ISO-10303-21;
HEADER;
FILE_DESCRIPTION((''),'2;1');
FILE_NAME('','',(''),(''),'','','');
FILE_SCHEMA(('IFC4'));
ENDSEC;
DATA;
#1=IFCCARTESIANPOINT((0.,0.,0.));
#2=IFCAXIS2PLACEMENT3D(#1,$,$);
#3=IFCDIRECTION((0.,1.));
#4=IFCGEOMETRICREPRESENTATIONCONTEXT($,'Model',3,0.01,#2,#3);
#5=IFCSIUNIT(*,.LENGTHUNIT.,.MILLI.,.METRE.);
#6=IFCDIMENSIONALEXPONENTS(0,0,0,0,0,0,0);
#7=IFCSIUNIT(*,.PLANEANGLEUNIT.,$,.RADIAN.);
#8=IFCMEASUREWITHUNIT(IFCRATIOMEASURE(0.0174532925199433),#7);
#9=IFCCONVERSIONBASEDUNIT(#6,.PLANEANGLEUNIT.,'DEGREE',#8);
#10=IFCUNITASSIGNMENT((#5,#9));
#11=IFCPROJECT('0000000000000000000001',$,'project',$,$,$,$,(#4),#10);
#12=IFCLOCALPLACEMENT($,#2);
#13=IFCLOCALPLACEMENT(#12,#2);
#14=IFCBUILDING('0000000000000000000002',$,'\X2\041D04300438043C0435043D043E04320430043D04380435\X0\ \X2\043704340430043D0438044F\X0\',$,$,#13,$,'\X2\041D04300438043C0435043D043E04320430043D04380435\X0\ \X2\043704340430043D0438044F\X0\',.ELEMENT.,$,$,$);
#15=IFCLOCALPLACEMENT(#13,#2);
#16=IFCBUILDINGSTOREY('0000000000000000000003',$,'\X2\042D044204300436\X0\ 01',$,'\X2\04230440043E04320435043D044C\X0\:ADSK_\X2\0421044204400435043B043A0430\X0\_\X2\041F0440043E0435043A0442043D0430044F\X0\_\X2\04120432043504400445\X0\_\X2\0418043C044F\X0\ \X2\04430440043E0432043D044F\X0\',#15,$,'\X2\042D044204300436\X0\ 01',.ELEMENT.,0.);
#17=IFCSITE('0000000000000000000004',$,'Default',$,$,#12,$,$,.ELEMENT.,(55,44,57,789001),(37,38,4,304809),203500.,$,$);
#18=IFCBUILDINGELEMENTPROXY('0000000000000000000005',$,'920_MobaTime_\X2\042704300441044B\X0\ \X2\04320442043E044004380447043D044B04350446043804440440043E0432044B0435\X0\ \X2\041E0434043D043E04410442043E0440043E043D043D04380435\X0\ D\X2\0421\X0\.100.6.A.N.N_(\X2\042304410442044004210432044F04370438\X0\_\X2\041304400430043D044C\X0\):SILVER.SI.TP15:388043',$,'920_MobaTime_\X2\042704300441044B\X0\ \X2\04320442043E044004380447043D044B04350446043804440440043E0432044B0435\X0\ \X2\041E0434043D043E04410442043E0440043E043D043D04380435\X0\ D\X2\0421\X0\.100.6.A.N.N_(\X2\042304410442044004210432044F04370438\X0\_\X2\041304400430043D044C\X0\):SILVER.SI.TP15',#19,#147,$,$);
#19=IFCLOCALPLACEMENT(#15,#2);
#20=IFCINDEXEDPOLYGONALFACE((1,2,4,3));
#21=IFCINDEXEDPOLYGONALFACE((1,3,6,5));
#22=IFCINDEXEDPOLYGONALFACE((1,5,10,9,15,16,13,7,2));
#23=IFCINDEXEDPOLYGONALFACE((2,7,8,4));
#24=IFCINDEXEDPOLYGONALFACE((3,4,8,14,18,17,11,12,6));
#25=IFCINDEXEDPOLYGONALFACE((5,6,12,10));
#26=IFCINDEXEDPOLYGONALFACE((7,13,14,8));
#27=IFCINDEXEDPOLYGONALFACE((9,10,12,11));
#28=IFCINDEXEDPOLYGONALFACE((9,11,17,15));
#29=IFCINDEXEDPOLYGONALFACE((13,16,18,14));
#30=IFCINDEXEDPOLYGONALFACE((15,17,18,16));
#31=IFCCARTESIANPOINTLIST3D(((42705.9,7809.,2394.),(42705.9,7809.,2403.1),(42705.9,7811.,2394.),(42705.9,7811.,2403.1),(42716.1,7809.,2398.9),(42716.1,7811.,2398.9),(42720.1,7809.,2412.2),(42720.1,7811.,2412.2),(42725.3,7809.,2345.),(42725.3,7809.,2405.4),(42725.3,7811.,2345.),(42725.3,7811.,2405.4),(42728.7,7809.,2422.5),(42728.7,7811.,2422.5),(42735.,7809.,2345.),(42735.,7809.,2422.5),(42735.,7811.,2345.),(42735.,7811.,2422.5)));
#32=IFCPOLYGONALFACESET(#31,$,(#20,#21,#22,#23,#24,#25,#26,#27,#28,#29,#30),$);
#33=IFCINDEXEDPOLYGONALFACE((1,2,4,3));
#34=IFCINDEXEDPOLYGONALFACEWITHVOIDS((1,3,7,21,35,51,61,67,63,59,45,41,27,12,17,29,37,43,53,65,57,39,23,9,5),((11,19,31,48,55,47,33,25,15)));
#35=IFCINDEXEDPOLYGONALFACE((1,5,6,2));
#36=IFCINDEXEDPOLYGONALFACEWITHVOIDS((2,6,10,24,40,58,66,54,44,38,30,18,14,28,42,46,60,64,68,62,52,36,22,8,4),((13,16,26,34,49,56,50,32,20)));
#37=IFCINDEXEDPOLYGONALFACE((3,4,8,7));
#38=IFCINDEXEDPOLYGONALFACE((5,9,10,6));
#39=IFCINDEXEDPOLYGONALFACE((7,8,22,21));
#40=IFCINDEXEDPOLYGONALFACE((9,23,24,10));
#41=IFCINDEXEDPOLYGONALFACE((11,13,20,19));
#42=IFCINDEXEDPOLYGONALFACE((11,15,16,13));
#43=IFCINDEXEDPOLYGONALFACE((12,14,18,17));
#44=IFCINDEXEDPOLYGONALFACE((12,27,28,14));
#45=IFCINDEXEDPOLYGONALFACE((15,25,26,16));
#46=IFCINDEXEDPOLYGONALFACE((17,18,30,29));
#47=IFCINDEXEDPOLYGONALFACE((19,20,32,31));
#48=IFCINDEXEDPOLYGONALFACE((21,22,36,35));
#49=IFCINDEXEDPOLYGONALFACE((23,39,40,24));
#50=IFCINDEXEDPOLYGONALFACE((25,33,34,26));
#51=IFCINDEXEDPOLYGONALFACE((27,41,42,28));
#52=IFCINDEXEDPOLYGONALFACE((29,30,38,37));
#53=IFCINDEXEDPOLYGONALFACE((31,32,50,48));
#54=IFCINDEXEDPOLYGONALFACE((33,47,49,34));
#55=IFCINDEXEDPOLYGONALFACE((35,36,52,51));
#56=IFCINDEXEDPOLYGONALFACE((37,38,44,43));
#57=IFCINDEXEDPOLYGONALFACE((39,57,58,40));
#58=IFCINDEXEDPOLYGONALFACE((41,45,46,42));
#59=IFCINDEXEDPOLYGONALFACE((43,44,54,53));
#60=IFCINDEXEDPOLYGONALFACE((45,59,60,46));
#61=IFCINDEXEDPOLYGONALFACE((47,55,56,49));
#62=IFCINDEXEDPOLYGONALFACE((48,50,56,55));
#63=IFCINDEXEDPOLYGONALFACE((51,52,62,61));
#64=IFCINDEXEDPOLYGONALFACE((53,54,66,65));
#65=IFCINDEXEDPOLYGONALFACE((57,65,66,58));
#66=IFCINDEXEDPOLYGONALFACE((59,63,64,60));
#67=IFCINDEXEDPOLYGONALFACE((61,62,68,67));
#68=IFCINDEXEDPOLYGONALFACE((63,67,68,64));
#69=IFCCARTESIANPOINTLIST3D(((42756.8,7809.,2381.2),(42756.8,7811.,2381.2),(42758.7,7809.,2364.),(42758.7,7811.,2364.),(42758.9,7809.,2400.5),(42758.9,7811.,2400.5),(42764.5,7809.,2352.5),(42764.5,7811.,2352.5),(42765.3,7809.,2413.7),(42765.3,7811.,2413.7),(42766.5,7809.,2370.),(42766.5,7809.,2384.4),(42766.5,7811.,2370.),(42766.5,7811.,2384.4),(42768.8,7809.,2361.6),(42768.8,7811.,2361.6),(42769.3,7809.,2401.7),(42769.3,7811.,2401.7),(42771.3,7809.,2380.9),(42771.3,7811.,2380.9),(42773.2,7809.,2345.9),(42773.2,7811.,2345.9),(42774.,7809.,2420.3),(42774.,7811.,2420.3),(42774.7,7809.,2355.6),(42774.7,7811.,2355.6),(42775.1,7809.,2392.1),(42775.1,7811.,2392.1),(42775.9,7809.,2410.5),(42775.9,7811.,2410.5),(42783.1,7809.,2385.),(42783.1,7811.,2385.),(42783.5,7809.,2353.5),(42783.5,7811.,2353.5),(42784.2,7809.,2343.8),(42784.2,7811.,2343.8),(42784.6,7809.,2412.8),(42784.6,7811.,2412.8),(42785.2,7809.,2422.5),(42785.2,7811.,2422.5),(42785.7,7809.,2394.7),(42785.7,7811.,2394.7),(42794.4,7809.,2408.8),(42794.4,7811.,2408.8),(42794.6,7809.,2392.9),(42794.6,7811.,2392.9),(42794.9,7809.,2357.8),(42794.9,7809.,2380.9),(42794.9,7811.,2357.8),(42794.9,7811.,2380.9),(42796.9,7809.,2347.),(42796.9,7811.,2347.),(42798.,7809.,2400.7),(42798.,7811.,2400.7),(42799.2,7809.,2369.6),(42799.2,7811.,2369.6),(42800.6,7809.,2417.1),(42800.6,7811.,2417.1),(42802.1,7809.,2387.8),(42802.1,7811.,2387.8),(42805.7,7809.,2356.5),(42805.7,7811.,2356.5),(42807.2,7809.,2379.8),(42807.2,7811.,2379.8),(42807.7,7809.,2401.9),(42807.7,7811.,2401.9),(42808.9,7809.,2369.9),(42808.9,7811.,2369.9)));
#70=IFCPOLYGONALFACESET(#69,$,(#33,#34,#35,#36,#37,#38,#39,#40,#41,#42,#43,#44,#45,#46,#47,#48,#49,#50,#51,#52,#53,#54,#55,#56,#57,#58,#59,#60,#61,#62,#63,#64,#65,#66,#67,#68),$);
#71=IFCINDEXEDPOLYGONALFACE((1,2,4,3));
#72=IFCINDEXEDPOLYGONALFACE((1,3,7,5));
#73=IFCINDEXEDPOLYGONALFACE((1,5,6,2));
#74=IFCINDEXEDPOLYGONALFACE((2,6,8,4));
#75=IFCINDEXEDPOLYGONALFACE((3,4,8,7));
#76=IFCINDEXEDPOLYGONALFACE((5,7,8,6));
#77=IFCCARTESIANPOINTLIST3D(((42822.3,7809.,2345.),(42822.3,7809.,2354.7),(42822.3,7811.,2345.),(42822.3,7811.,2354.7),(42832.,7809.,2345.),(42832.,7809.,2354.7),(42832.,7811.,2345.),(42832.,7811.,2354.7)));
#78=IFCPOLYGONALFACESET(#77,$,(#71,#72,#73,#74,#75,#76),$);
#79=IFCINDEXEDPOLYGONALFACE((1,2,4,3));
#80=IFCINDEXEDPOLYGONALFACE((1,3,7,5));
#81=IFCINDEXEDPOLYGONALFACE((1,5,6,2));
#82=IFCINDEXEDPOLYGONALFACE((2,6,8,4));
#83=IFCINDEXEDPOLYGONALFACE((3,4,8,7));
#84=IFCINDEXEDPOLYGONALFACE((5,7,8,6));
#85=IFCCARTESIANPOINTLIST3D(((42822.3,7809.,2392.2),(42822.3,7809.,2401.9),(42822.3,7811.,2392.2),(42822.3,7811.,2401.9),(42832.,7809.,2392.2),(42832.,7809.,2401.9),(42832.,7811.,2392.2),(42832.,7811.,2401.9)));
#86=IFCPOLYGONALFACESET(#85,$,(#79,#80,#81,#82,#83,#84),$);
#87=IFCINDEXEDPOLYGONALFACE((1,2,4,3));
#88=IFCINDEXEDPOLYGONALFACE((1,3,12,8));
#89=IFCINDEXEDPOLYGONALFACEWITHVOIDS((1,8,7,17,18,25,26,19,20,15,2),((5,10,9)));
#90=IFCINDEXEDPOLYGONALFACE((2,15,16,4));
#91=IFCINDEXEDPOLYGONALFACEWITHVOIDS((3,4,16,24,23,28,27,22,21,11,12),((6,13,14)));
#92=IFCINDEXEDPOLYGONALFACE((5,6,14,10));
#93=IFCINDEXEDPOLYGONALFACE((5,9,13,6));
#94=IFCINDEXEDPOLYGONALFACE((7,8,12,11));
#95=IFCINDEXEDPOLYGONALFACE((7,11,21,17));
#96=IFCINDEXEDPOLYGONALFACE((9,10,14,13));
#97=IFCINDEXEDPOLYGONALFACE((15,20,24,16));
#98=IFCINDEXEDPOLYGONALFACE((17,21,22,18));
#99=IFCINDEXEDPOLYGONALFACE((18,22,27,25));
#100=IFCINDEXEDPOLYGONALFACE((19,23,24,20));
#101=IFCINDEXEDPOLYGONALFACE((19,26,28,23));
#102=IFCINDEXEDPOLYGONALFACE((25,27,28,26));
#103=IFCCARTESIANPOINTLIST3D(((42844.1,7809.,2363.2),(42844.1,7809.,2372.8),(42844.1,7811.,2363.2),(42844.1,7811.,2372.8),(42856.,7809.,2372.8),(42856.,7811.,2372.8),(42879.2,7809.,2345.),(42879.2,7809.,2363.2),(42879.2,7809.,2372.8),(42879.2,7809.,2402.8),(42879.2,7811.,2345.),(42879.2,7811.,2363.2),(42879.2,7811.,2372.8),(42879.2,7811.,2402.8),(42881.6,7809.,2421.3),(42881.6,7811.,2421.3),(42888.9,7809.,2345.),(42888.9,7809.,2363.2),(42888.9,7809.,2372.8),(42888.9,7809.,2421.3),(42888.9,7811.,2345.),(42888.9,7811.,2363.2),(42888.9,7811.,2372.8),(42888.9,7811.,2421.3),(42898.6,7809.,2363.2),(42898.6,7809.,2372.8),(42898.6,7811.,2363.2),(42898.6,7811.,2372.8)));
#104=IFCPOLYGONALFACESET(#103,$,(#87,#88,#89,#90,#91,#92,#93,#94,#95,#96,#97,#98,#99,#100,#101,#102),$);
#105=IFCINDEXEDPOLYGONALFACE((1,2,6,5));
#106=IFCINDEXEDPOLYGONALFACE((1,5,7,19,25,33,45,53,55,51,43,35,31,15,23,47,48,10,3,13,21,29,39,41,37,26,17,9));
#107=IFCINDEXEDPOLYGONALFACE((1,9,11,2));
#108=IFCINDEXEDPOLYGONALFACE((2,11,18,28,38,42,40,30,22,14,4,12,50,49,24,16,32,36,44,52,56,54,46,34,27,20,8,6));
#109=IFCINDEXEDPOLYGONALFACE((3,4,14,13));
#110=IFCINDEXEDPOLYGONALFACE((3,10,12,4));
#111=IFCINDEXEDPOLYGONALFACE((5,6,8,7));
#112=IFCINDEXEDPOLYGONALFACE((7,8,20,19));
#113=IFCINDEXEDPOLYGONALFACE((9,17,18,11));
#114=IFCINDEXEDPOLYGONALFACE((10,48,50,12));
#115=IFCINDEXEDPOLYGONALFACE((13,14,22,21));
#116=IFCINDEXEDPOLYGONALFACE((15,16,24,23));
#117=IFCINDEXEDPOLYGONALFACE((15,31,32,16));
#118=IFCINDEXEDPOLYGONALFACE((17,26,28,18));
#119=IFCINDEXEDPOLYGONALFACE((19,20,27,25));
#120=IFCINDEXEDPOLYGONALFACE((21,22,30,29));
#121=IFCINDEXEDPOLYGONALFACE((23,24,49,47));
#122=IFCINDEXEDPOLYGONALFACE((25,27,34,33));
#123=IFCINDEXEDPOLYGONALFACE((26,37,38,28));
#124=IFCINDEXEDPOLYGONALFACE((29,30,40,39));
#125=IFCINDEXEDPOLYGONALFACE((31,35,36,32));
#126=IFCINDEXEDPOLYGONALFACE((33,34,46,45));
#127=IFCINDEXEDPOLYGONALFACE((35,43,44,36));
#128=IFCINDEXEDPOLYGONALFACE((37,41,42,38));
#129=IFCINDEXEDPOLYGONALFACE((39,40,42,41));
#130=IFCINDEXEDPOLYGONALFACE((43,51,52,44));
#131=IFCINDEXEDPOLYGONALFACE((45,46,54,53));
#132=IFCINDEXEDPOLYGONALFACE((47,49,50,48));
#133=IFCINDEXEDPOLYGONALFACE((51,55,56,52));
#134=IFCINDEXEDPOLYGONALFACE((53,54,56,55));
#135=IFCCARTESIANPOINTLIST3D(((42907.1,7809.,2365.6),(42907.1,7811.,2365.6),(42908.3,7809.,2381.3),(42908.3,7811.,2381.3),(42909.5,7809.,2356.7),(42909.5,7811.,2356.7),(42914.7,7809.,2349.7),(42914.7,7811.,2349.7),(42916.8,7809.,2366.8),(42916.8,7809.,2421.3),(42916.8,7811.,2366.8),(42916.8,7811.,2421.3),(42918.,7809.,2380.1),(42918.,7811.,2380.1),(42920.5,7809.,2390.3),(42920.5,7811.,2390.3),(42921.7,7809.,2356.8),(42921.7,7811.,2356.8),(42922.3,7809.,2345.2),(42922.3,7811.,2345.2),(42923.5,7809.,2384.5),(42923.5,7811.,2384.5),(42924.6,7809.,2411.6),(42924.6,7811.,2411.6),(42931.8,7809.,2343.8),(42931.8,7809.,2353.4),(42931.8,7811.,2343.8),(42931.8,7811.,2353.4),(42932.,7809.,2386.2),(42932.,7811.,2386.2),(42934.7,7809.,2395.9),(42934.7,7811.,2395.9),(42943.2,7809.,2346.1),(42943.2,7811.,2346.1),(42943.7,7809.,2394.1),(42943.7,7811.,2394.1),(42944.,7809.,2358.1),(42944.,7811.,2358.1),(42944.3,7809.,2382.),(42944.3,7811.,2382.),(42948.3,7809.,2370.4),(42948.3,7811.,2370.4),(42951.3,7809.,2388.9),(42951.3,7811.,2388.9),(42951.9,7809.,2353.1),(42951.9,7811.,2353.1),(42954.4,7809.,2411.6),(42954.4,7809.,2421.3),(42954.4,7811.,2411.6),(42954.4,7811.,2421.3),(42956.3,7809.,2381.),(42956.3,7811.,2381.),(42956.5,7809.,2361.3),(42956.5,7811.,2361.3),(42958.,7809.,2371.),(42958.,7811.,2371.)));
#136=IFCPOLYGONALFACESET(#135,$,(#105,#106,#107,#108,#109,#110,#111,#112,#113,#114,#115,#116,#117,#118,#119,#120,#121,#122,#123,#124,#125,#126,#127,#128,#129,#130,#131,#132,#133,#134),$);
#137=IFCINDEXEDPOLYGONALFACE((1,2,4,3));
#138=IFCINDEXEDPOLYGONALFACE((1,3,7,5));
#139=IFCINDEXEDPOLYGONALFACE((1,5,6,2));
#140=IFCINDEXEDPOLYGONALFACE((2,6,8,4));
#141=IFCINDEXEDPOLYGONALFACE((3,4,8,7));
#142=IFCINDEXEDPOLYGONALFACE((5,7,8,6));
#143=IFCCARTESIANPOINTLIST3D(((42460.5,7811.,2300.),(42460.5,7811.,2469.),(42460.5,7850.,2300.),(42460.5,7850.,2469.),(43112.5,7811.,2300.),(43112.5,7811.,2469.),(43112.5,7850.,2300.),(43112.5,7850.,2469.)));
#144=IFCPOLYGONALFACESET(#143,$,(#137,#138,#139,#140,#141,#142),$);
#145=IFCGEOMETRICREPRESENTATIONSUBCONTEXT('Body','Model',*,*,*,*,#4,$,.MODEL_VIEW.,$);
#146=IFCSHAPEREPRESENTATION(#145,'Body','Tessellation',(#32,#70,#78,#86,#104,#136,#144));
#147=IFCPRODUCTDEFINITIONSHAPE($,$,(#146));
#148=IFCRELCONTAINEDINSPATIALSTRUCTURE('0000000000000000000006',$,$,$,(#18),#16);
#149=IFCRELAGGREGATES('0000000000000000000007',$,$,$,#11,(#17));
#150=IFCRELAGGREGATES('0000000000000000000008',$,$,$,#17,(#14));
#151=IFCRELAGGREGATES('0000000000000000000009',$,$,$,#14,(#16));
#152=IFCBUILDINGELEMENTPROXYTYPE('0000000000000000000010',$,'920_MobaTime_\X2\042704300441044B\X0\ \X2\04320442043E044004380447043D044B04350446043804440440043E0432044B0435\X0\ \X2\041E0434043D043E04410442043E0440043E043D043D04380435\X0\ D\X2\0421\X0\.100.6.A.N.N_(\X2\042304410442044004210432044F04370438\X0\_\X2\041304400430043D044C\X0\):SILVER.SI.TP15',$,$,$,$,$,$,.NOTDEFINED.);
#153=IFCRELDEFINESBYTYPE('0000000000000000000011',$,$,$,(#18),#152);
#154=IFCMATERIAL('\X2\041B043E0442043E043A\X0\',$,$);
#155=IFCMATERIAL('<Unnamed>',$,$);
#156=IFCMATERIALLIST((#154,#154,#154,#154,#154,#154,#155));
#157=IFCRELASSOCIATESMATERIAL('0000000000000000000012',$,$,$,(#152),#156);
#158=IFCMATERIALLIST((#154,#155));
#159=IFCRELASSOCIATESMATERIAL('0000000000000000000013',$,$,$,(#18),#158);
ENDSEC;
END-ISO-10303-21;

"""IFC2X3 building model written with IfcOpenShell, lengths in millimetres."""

from ifc_helpers import new_model, entity, si_unit, converted_unit, direction, frame, origin, origin_2d_with_axis, place, context, subcontext, project, spatial, polyline, rectangle, outline, extrude, source, transform, mapped, material, material_list, type_object, type_shapes, element, save


model = new_model("IFC2X3")

# Units and contexts
model_context = context("Model", 3, precision=0.01, world=origin(), true_north=direction((0.0, 1.0)))
body_context = subcontext(model_context, "Body", "Model", "MODEL_VIEW")
ifc_project = project(units=[si_unit("LENGTHUNIT", "METRE", prefix="MILLI"), converted_unit("PLANEANGLEUNIT", "DEGREE", entity("IfcRatioMeasure", 0.0174532925199433), si_unit("PLANEANGLEUNIT", "RADIAN"), dimensions=[0, 0, 0, 0, 0, 0, 0])], contexts=[model_context])

# Site, building, storey
site_placement = place(None, origin())
site = spatial("IfcSite", under=ifc_project, at=site_placement, Name="Default", CompositionType="ELEMENT", RefLatitude=(55, 44, 57, 789001), RefLongitude=(37, 38, 4, 304809), RefElevation=203500.0)
building_placement = place(site_placement, origin())
building = spatial("IfcBuilding", under=site, at=building_placement, Name="Наименование здания", LongName="Наименование здания", CompositionType="ELEMENT")
storey_placement = place(building_placement, origin())
storey = spatial("IfcBuildingStorey", under=building, at=storey_placement, Name="Этаж 01", ObjectType="Уровень:ADSK_Стрелка_Проектная_Вверх_Имя уровня", LongName="Этаж 01", CompositionType="ELEMENT", Elevation=0.0)

# Building element proxy
ifc_material_1 = material(Name="Лоток")
ifc_material_2 = material(Name="<Unnamed>")
ifc_material_list_1 = material_list([ifc_material_1, ifc_material_1, ifc_material_1, ifc_material_1, ifc_material_1, ifc_material_1, ifc_material_2])
building_element_proxy_type = type_object("IfcBuildingElementProxyType", Name="920_MobaTime_Часы вторичныецифровые Односторонние DС.100.6.A.N.N_(УстрСвязи_Грань):SILVER.SI.TP15", PredefinedType="NOTDEFINED", material=ifc_material_list_1)
shared_shape = source(origin(), body_context, "Body", "SweptSolid", [
    extrude(outline(polyline([(-49.3, -13.1), (28.2, -13.1), (28.2, -6.8), (17.9, 1.8), (8.8, 16.0), (-0.3, 16.0), (4.6, 5.8), (11.1, -3.4), (-49.3, -3.4), (-49.3, -13.1)])), frame((-64.6, 9.8, 39.0), z_axis=(0.0, 0.0, 1.0), x_axis=(0.0, 1.0, 0.0)), (0.0, 0.0, 1.0), 2.0),
    extrude(outline(polyline([(2.2, -27.6), (19.0, -27.6), (30.5, -16.1), (33.3, -4.9), (31.0, 5.8), (21.8, 17.2), (5.2, 27.3), (-11.1, 33.0), (-24.0, 32.7), (-33.6, 27.6), (-40.3, 18.6), (-42.8, 5.7), (-38.0, -6.3), (-27.2, -14.9), (-17.5, -17.7), (-8.2, -16.4), (-0.3, -11.9), (5.1, -4.5), (7.3, 6.2), (4.0, 17.2), (18.4, 7.3), (23.6, -2.4), (22.0, -11.4), (14.2, -18.4), (5.3, -18.3), (2.2, -27.6)]), holes=[polyline([(-9.0, 23.3), (-1.3, 14.3), (-2.5, 2.0), (-11.4, -7.0), (-23.4, -6.0), (-32.2, 2.9), (-31.2, 15.1), (-25.6, 22.1), (-17.5, 24.9), (-9.0, 23.3)])]), frame((-2.7, 3.6, 39.0), z_axis=(0.0, 0.0, 1.0), x_axis=(-0.427649, 0.903945, 0.0)), (0.0, 0.0, 1.0), 2.0),
    extrude(rectangle(XDim=9.7, YDim=9.7, at=origin_2d_with_axis()), frame((40.6, -34.7, 39.0)), (0.0, 0.0, 1.0), 2.0),
    extrude(rectangle(XDim=9.7, YDim=9.7, at=origin_2d_with_axis()), frame((40.6, 12.6, 39.0)), (0.0, 0.0, 1.0), 2.0),
    extrude(outline(polyline([(-0.9, -28.1), (8.8, -28.1), (8.8, -9.9), (18.5, -9.9), (18.5, -0.2), (8.8, -0.2), (8.8, 48.3), (1.5, 48.3), (-36.0, -0.2), (-36.0, -9.9), (-0.9, -9.9), (-0.9, -28.1)]), holes=[polyline([(-0.9, -0.2), (-24.1, -0.2), (-0.9, 29.7), (-0.9, -0.2)])]), frame((93.6, -11.4, 39.0)), (0.0, 0.0, 1.0), 2.0),
    extrude(outline(polyline([(3.3, -28.3), (12.5, -28.3), (20.5, -25.0), (26.8, -18.9), (30.7, -10.0), (31.4, 1.6), (26.9, 11.8), (20.1, 18.4), (11.1, 22.3), (1.0, 23.3), (-7.9, 20.4), (-14.9, 14.5), (-18.9, 6.2), (-17.1, -9.0), (-36.7, 0.5), (-29.1, 29.2), (-38.5, 31.7), (-48.1, -4.6), (-11.6, -23.1), (-8.0, -14.0), (-10.8, -7.6), (-10.2, 1.1), (-3.0, 11.8), (9.2, 12.8), (20.0, 5.5), (21.4, -7.5), (15.5, -16.4), (4.6, -18.6), (3.3, -28.3)])), frame((147.1, -8.5, 39.0), z_axis=(0.0, 0.0, 1.0), x_axis=(0.256974, -0.966418, 0.0)), (0.0, 0.0, 1.0), 2.0),
    extrude(rectangle(XDim=652.0, YDim=169.0, at=origin_2d_with_axis()), frame((0.0, 0.0, 0.0), z_axis=(0.0, 0.0, 1.0), x_axis=(-1.0, 0.0, 0.0)), (0.0, 0.0, 1.0), 39.0),
])
type_shapes(building_element_proxy_type, [shared_shape])
ifc_material_list_2 = material_list([ifc_material_1, ifc_material_2])
for number, where, z_axis, x_axis, name in (
    (1, (42786.5, 7850.0, 2384.5), (0.0, -1.0, 0.0), (1.0, 0.0, 0.0), "920_MobaTime_Часы вторичныецифровые Односторонние DС.100.6.A.N.N_(УстрСвязи_Грань):SILVER.SI.TP15:388043"),
):
    element("IfcBuildingElementProxy", number, at=place(storey_placement, frame(where, z_axis=z_axis, x_axis=x_axis)), inside=storey, type_object=building_element_proxy_type, material=ifc_material_list_2, Name=name, ObjectType="920_MobaTime_Часы вторичныецифровые Односторонние DС.100.6.A.N.N_(УстрСвязи_Грань):SILVER.SI.TP15", context=body_context, shape_type="MappedRepresentation", body=[
        mapped(shared_shape, transform((0.0, 0.0, 0.0), scale=1.0)),
    ])

save(model, "model.ifc")
